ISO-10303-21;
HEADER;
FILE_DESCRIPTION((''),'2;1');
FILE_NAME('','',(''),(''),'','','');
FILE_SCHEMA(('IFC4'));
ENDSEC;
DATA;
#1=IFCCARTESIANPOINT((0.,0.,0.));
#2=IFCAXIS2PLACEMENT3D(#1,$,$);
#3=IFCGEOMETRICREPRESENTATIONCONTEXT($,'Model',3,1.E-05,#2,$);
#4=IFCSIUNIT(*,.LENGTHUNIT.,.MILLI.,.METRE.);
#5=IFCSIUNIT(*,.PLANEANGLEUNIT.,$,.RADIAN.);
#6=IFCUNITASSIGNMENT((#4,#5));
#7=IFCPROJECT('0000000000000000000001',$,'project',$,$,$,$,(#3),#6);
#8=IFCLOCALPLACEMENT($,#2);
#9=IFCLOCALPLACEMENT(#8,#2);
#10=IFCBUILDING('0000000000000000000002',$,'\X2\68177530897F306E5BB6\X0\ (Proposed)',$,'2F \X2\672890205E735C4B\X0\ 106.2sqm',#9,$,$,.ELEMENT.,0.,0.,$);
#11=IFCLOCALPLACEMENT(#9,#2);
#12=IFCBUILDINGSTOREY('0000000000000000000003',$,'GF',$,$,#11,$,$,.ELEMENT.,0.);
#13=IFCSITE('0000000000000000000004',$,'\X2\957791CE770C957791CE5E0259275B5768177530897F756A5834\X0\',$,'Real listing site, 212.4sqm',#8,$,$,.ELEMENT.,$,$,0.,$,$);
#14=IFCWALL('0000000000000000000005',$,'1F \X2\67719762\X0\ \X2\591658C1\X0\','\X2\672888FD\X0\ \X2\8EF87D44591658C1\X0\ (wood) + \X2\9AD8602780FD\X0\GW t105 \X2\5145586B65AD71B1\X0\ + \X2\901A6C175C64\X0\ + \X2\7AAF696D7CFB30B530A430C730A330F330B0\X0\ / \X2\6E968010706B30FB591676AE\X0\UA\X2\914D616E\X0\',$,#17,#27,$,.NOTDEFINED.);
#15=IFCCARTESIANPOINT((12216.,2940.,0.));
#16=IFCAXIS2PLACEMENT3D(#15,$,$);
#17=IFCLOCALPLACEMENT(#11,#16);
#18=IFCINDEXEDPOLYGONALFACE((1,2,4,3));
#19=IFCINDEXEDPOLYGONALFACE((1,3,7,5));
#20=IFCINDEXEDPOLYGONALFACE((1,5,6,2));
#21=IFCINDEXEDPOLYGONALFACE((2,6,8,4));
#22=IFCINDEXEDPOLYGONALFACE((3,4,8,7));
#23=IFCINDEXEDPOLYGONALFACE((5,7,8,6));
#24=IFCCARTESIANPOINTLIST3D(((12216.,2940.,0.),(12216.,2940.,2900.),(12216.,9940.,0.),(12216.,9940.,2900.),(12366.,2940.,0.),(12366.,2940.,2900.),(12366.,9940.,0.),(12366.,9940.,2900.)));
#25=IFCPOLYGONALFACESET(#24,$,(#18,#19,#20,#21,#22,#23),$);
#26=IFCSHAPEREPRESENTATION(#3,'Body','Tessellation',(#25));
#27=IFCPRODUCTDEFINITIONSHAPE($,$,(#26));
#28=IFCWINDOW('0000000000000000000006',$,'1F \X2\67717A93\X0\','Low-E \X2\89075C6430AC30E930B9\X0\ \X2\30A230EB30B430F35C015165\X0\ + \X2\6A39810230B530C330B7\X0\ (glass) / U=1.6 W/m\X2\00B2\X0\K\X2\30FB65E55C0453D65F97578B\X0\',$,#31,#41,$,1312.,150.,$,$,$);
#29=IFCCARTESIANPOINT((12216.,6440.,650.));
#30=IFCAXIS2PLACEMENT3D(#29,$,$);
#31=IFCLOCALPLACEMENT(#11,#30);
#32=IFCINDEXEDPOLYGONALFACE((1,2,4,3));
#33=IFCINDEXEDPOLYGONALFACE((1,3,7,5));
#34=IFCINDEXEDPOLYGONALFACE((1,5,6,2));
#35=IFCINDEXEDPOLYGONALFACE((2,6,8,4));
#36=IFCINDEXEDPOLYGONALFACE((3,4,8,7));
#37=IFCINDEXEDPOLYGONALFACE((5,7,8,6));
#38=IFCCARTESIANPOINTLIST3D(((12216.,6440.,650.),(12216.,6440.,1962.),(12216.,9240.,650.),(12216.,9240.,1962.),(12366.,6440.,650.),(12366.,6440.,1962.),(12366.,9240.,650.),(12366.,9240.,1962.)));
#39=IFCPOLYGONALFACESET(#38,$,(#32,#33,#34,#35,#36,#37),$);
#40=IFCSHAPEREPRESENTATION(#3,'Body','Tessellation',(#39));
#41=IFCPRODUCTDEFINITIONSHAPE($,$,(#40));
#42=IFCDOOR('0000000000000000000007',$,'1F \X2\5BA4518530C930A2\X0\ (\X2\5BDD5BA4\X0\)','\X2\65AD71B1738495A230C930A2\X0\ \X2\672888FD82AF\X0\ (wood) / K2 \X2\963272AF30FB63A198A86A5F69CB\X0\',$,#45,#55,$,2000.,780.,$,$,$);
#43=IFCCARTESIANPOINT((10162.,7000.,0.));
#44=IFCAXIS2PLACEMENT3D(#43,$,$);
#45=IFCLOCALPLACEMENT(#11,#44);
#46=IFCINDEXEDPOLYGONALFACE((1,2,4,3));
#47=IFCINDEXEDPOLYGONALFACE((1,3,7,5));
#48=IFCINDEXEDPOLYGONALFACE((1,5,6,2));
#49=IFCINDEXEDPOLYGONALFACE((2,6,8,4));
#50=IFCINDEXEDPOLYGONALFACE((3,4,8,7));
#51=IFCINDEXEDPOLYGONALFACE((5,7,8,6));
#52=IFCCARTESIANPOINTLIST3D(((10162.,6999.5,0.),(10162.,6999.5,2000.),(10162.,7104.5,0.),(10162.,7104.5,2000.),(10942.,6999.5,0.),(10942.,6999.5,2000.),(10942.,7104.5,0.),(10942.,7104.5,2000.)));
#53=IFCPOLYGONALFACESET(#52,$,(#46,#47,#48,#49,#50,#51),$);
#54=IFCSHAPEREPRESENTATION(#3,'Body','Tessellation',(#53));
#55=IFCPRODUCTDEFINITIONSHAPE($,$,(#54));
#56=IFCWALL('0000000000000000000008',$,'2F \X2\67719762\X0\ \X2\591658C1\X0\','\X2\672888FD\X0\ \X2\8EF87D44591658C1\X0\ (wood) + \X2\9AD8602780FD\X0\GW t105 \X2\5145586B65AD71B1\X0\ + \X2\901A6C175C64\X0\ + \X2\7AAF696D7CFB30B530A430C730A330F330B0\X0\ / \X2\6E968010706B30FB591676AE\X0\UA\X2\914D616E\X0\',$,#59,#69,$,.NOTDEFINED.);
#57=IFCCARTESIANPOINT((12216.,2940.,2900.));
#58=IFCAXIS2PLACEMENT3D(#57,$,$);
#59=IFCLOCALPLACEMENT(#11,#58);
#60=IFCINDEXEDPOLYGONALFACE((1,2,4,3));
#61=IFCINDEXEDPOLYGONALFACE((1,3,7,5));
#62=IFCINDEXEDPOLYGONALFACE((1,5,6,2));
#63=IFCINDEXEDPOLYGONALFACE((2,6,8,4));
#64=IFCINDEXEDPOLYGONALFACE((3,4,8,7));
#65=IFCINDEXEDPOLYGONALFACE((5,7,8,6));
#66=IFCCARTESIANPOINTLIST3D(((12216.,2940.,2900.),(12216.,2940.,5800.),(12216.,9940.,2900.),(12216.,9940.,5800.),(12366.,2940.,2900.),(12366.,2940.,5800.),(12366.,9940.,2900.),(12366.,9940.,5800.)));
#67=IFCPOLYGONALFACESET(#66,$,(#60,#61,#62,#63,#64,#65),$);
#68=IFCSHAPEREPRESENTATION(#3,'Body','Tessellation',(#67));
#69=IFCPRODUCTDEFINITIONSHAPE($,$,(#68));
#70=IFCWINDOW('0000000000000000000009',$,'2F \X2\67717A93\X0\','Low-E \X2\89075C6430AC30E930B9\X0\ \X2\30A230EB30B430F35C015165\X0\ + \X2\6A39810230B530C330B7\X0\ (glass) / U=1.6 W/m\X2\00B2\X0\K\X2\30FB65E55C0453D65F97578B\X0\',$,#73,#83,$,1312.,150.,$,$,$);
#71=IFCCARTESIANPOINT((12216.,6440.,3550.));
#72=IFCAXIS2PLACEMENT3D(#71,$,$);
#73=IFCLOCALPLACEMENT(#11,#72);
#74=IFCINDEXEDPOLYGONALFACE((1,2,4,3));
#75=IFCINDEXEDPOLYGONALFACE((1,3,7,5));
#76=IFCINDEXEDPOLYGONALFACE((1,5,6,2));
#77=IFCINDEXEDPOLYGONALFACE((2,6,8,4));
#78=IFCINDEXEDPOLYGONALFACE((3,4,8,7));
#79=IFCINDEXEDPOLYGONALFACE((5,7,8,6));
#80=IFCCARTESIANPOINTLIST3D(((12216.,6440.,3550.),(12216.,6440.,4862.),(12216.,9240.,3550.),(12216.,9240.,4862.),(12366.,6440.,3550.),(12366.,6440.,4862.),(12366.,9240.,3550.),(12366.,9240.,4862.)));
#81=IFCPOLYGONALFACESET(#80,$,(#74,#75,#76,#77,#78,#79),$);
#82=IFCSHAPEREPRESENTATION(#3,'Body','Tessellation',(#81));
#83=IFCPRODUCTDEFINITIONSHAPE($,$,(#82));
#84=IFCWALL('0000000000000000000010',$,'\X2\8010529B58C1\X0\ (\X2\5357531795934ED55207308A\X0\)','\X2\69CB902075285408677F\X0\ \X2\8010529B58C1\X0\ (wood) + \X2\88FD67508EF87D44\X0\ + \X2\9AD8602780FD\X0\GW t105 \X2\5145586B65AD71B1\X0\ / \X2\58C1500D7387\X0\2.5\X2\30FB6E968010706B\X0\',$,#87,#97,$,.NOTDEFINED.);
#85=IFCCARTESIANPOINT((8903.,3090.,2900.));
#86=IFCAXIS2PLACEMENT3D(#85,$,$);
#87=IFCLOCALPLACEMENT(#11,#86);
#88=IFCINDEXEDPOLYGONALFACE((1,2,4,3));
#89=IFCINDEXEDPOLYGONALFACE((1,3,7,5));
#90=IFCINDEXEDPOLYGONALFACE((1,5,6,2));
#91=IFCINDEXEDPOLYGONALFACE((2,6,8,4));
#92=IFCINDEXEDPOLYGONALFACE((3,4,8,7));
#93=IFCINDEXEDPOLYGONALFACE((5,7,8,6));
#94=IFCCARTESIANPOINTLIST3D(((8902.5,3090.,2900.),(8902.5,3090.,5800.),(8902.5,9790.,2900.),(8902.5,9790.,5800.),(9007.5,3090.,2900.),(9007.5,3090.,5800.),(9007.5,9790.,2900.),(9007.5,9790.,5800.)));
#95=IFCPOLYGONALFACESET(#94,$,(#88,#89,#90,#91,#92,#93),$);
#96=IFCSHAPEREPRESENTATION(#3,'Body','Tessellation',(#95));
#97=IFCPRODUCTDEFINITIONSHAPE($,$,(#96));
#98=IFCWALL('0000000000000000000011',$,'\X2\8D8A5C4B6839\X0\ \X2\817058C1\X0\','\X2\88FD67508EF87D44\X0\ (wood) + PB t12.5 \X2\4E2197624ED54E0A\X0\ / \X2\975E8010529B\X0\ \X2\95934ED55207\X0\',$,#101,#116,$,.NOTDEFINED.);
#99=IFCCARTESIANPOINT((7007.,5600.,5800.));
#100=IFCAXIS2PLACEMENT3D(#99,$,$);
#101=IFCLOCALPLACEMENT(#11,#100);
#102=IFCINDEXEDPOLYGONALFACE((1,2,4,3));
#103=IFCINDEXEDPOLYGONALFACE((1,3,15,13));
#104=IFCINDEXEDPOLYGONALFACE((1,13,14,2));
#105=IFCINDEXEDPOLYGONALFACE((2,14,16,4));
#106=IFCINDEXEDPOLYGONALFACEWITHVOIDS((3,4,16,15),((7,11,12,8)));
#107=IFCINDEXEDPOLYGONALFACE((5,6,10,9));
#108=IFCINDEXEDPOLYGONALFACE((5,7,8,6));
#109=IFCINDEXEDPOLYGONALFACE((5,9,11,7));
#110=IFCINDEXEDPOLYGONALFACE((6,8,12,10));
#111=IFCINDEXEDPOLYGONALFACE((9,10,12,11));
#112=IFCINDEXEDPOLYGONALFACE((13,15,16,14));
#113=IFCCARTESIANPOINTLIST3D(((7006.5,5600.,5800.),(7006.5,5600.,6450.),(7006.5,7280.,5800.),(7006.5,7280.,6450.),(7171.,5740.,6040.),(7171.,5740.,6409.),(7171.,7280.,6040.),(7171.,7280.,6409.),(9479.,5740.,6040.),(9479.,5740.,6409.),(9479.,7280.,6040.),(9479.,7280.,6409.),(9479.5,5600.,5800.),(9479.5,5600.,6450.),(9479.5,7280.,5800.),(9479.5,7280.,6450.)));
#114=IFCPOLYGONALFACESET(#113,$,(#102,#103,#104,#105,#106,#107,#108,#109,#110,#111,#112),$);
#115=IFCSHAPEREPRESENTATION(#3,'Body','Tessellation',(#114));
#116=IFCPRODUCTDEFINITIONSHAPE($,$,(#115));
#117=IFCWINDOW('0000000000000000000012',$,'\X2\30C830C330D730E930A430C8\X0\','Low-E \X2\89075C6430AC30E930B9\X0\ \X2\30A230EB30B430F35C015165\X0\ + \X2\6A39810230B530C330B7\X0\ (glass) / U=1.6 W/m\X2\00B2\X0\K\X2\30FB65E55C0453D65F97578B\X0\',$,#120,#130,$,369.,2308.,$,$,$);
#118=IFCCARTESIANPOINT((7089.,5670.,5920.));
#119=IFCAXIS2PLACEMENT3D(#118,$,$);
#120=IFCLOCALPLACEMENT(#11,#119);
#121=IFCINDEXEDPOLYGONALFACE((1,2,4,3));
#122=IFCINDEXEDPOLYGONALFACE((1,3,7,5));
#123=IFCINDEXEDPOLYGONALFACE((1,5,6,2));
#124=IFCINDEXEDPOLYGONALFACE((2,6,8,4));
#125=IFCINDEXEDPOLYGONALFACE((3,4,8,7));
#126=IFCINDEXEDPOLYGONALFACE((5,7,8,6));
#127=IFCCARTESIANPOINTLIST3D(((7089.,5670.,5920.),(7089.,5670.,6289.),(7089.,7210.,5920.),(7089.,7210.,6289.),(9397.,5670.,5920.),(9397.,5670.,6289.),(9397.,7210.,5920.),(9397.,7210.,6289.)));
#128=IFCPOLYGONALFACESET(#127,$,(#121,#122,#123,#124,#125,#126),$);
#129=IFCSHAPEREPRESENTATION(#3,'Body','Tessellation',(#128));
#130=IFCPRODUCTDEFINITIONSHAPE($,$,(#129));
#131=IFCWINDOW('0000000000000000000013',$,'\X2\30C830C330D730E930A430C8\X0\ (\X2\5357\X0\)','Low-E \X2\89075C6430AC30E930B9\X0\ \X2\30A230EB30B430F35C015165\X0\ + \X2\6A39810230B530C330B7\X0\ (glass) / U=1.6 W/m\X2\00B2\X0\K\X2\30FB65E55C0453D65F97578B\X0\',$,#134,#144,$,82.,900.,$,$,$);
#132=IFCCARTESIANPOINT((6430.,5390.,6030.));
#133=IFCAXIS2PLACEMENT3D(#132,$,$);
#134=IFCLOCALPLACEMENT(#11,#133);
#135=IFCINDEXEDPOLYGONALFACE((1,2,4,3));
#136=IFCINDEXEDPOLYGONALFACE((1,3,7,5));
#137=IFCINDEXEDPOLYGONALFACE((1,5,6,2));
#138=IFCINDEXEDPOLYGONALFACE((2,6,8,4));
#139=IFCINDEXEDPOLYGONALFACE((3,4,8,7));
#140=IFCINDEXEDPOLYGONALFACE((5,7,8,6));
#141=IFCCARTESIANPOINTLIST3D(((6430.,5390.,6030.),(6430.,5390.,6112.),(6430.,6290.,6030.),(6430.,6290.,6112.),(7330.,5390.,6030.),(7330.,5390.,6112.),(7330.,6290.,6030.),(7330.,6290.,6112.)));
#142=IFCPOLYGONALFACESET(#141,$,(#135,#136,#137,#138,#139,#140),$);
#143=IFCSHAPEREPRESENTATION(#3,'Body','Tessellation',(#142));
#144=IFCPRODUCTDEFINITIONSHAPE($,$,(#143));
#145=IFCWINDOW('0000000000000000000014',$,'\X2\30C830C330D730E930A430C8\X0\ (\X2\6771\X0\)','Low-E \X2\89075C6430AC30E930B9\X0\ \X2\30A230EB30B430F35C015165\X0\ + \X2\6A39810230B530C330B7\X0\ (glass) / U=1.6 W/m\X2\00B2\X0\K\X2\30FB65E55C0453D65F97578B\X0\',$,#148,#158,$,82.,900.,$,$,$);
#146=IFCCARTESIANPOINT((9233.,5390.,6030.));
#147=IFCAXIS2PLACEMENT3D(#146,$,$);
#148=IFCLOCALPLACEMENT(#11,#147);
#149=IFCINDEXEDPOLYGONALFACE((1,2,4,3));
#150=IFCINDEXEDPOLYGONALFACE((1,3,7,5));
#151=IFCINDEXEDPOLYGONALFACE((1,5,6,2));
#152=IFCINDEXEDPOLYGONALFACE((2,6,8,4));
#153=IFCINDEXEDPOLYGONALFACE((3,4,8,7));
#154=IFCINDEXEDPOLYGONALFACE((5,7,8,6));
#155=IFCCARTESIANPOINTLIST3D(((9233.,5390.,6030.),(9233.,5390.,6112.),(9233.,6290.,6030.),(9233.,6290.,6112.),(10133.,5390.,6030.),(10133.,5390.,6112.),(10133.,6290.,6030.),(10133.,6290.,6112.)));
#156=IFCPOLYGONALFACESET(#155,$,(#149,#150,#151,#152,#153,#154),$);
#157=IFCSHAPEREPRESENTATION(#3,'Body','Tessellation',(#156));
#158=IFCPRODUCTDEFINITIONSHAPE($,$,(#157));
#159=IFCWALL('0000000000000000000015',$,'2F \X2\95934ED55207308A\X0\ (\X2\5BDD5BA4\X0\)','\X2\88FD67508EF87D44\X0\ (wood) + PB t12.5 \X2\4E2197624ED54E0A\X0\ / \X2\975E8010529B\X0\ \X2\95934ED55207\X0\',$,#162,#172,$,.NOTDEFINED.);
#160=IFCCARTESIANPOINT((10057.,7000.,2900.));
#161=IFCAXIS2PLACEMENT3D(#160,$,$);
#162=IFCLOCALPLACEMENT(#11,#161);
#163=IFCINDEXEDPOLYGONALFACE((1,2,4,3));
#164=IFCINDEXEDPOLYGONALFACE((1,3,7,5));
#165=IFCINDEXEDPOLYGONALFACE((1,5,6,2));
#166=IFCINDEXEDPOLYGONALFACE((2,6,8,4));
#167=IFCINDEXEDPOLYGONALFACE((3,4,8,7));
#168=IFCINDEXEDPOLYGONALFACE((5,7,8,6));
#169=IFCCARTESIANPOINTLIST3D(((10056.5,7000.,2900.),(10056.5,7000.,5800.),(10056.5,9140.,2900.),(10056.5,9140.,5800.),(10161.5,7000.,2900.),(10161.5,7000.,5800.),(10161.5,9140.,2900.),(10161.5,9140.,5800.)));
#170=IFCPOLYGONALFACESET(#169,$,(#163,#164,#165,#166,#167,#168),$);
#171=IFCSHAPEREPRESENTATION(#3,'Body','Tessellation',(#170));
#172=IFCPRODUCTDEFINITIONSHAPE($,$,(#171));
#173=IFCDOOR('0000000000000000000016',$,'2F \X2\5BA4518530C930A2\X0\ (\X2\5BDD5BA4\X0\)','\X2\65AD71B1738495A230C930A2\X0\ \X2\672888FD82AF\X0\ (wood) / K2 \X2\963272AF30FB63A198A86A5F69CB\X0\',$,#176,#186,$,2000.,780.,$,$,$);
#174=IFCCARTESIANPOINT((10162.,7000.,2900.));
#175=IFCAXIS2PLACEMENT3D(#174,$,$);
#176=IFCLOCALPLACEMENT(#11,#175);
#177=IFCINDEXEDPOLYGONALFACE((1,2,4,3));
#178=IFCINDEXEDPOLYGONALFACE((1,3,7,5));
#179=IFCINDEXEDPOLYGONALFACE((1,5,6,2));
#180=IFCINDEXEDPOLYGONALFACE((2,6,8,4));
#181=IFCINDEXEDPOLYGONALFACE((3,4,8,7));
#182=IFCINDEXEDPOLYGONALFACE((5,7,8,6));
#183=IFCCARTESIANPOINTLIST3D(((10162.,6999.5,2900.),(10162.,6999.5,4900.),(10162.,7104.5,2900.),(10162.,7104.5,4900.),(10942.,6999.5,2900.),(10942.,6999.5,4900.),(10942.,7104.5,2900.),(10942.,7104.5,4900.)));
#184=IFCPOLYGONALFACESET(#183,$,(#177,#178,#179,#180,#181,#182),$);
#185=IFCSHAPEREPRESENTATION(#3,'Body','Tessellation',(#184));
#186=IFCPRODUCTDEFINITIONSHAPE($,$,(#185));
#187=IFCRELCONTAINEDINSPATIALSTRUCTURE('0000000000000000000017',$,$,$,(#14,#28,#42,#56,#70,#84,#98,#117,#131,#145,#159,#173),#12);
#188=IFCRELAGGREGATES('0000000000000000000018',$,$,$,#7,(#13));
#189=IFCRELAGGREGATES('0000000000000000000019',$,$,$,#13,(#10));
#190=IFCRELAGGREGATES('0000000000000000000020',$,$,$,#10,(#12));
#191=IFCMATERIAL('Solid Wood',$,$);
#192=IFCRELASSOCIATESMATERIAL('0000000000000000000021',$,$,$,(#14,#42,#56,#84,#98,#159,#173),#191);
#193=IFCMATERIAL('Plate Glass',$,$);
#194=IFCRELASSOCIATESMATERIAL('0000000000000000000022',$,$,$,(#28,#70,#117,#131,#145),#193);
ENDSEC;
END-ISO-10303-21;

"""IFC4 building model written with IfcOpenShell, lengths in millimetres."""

from ifc_helpers import new_model, si_unit, frame, frame_2d, origin, place, context, project, spatial, rectangle, extrude, material, element, fill, save


model = new_model("IFC4")

# Units and contexts
model_context = context("Model", 3, precision=1e-05, world=origin())
ifc_project = project(units=[si_unit("LENGTHUNIT", "METRE", prefix="MILLI"), si_unit("PLANEANGLEUNIT", "RADIAN")], contexts=[model_context])

# Site, building, storey
site_placement = place(None, origin())
site = spatial("IfcSite", under=ifc_project, at=site_placement, Name="長野県長野市大字栗田西番場", ObjectType="Real listing site, 212.4sqm", CompositionType="ELEMENT", RefElevation=0.0)
building_placement = place(site_placement, origin())
building = spatial("IfcBuilding", under=site, at=building_placement, Name="栗田西の家 (Proposed)", ObjectType="2F 木造平屋 106.2sqm", CompositionType="ELEMENT", ElevationOfRefHeight=0.0, ElevationOfTerrain=0.0)
storey_placement = place(building_placement, origin())
storey = spatial("IfcBuildingStorey", under=building, at=storey_placement, Name="GF", CompositionType="ELEMENT", Elevation=0.0)

# Wall, opening, window
ifc_material_1 = material(Name="Solid Wood")
wall_1_placement = place(storey_placement, frame((12216.0, 2940.0, 0.0)))
wall_1 = element("IfcWall", 1, at=wall_1_placement, inside=storey, material=ifc_material_1, Name="1F 東面 外壁", Description="木製 軸組外壁 (wood) + 高性能GW t105 充填断熱 + 通気層 + 窯業系サイディング / 準耐火・外皮UA配慮", PredefinedType="NOTDEFINED", context=model_context, shape_type="SweptSolid", body=[
    extrude(rectangle(XDim=150.0, YDim=7000.0, at=frame_2d((75.0, 3500.0))), frame((12216.0, 2940.0, 0.0)), (0.0, 0.0, 1.0), 2900.0),
])
opening_1_placement = place(storey_placement, frame((12216.0, 6440.0, 650.0)))
opening_1 = element("IfcOpeningElement", 2, at=opening_1_placement, cuts=wall_1, PredefinedType="NOTDEFINED", context=model_context, shape_type="SweptSolid", body=[
    extrude(rectangle(XDim=150.0, YDim=2800.0, at=frame_2d((75.0, 1400.0))), frame((12216.0, 6440.0, 650.0)), (0.0, 0.0, 1.0), 1312.0),
])
ifc_material_2 = material(Name="Plate Glass")
window_1_placement = place(storey_placement, frame((12216.0, 6440.0, 650.0)))
window_1 = element("IfcWindow", 3, at=window_1_placement, inside=storey, material=ifc_material_2, Name="1F 東窓", Description="Low-E 複層ガラス アルゴン封入 + 樹脂サッシ (glass) / U=1.6 W/m²K・日射取得型", OverallHeight=1312.0, OverallWidth=150.0, context=model_context, shape_type="SweptSolid", body=[
    extrude(rectangle(XDim=150.0, YDim=2800.0, at=frame_2d((75.0, 1400.0))), frame((12216.0, 6440.0, 650.0)), (0.0, 0.0, 1.0), 1312.0),
])
fill(opening_1, window_1)

# Door
door_1_placement = place(storey_placement, frame((10162.0, 7000.0, 0.0)))
element("IfcDoor", 4, at=door_1_placement, inside=storey, material=ifc_material_1, Name="1F 室内ドア (寝室)", Description="断熱玄関ドア 木製芯 (wood) / K2 防犯・採風機構", OverallHeight=2000.0, OverallWidth=780.0, context=model_context, shape_type="SweptSolid", body=[
    extrude(rectangle(XDim=780.0, YDim=105.0, at=frame_2d((390.0, 52.0))), frame((10162.0, 7000.0, 0.0)), (0.0, 0.0, 1.0), 2000.0),
])

# Wall, opening, window
wall_2_placement = place(storey_placement, frame((12216.0, 2940.0, 2900.0)))
wall_2 = element("IfcWall", 5, at=wall_2_placement, inside=storey, material=ifc_material_1, Name="2F 東面 外壁", Description="木製 軸組外壁 (wood) + 高性能GW t105 充填断熱 + 通気層 + 窯業系サイディング / 準耐火・外皮UA配慮", PredefinedType="NOTDEFINED", context=model_context, shape_type="SweptSolid", body=[
    extrude(rectangle(XDim=150.0, YDim=7000.0, at=frame_2d((75.0, 3500.0))), frame((12216.0, 2940.0, 2900.0)), (0.0, 0.0, 1.0), 2900.0),
])
opening_2_placement = place(storey_placement, frame((12216.0, 6440.0, 3550.0)))
opening_2 = element("IfcOpeningElement", 6, at=opening_2_placement, cuts=wall_2, PredefinedType="NOTDEFINED", context=model_context, shape_type="SweptSolid", body=[
    extrude(rectangle(XDim=150.0, YDim=2800.0, at=frame_2d((75.0, 1400.0))), frame((12216.0, 6440.0, 3550.0)), (0.0, 0.0, 1.0), 1312.0),
])
window_2_placement = place(storey_placement, frame((12216.0, 6440.0, 3550.0)))
window_2 = element("IfcWindow", 7, at=window_2_placement, inside=storey, material=ifc_material_2, Name="2F 東窓", Description="Low-E 複層ガラス アルゴン封入 + 樹脂サッシ (glass) / U=1.6 W/m²K・日射取得型", OverallHeight=1312.0, OverallWidth=150.0, context=model_context, shape_type="SweptSolid", body=[
    extrude(rectangle(XDim=150.0, YDim=2800.0, at=frame_2d((75.0, 1400.0))), frame((12216.0, 6440.0, 3550.0)), (0.0, 0.0, 1.0), 1312.0),
])
fill(opening_2, window_2)

# Wall
wall_3_placement = place(storey_placement, frame((8903.0, 3090.0, 2900.0)))
element("IfcWall", 8, at=wall_3_placement, inside=storey, material=ifc_material_1, Name="耐力壁 (南北間仕切り)", Description="構造用合板 耐力壁 (wood) + 製材軸組 + 高性能GW t105 充填断熱 / 壁倍率2.5・準耐火", PredefinedType="NOTDEFINED", context=model_context, shape_type="SweptSolid", body=[
    extrude(rectangle(XDim=105.0, YDim=6700.0, at=frame_2d((52.0, 3350.0))), frame((8903.0, 3090.0, 2900.0)), (0.0, 0.0, 1.0), 2900.0),
])

# Wall, openings, windows
wall_4_placement = place(storey_placement, frame((7007.0, 5600.0, 5800.0)))
wall_4 = element("IfcWall", 9, at=wall_4_placement, inside=storey, material=ifc_material_1, Name="越屋根 腰壁", Description="製材軸組 (wood) + PB t12.5 両面仕上 / 非耐力 間仕切", PredefinedType="NOTDEFINED", context=model_context, shape_type="SweptSolid", body=[
    extrude(rectangle(XDim=2473.0, YDim=1680.0, at=frame_2d((1236.0, 840.0))), frame((7007.0, 5600.0, 5800.0)), (0.0, 0.0, 1.0), 650.0),
])
opening_3_placement = place(storey_placement, frame((7089.0, 5670.0, 5920.0)))
opening_3 = element("IfcOpeningElement", 10, at=opening_3_placement, cuts=wall_4, PredefinedType="NOTDEFINED", context=model_context, shape_type="SweptSolid", body=[
    extrude(rectangle(XDim=2308.0, YDim=1540.0, at=frame_2d((1154.0, 770.0))), frame((7089.0, 5670.0, 5920.0)), (0.0, 0.0, 1.0), 369.0),
])
opening_4_placement = place(storey_placement, frame((6430.0, 5390.0, 6030.0)))
opening_4 = element("IfcOpeningElement", 11, at=opening_4_placement, cuts=wall_4, PredefinedType="NOTDEFINED", context=model_context, shape_type="SweptSolid", body=[
    extrude(rectangle(XDim=900.0, YDim=900.0, at=frame_2d((450.0, 450.0))), frame((6430.0, 5390.0, 6030.0)), (0.0, 0.0, 1.0), 82.0),
])
opening_5_placement = place(storey_placement, frame((9233.0, 5390.0, 6030.0)))
opening_5 = element("IfcOpeningElement", 12, at=opening_5_placement, cuts=wall_4, PredefinedType="NOTDEFINED", context=model_context, shape_type="SweptSolid", body=[
    extrude(rectangle(XDim=900.0, YDim=900.0, at=frame_2d((450.0, 450.0))), frame((9233.0, 5390.0, 6030.0)), (0.0, 0.0, 1.0), 82.0),
])
window_3_placement = place(storey_placement, frame((7089.0, 5670.0, 5920.0)))
window_3 = element("IfcWindow", 13, at=window_3_placement, inside=storey, material=ifc_material_2, Name="トップライト", Description="Low-E 複層ガラス アルゴン封入 + 樹脂サッシ (glass) / U=1.6 W/m²K・日射取得型", OverallHeight=369.0, OverallWidth=2308.0, context=model_context, shape_type="SweptSolid", body=[
    extrude(rectangle(XDim=2308.0, YDim=1540.0, at=frame_2d((1154.0, 770.0))), frame((7089.0, 5670.0, 5920.0)), (0.0, 0.0, 1.0), 369.0),
])
fill(opening_3, window_3)
window_4_placement = place(storey_placement, frame((6430.0, 5390.0, 6030.0)))
window_4 = element("IfcWindow", 14, at=window_4_placement, inside=storey, material=ifc_material_2, Name="トップライト (南)", Description="Low-E 複層ガラス アルゴン封入 + 樹脂サッシ (glass) / U=1.6 W/m²K・日射取得型", OverallHeight=82.0, OverallWidth=900.0, context=model_context, shape_type="SweptSolid", body=[
    extrude(rectangle(XDim=900.0, YDim=900.0, at=frame_2d((450.0, 450.0))), frame((6430.0, 5390.0, 6030.0)), (0.0, 0.0, 1.0), 82.0),
])
fill(opening_4, window_4)
window_5_placement = place(storey_placement, frame((9233.0, 5390.0, 6030.0)))
window_5 = element("IfcWindow", 15, at=window_5_placement, inside=storey, material=ifc_material_2, Name="トップライト (東)", Description="Low-E 複層ガラス アルゴン封入 + 樹脂サッシ (glass) / U=1.6 W/m²K・日射取得型", OverallHeight=82.0, OverallWidth=900.0, context=model_context, shape_type="SweptSolid", body=[
    extrude(rectangle(XDim=900.0, YDim=900.0, at=frame_2d((450.0, 450.0))), frame((9233.0, 5390.0, 6030.0)), (0.0, 0.0, 1.0), 82.0),
])
fill(opening_5, window_5)

# Wall
wall_5_placement = place(storey_placement, frame((10057.0, 7000.0, 2900.0)))
element("IfcWall", 16, at=wall_5_placement, inside=storey, material=ifc_material_1, Name="2F 間仕切り (寝室)", Description="製材軸組 (wood) + PB t12.5 両面仕上 / 非耐力 間仕切", PredefinedType="NOTDEFINED", context=model_context, shape_type="SweptSolid", body=[
    extrude(rectangle(XDim=105.0, YDim=2140.0, at=frame_2d((52.0, 1070.0))), frame((10057.0, 7000.0, 2900.0)), (0.0, 0.0, 1.0), 2900.0),
])

# Door
door_2_placement = place(storey_placement, frame((10162.0, 7000.0, 2900.0)))
element("IfcDoor", 17, at=door_2_placement, inside=storey, material=ifc_material_1, Name="2F 室内ドア (寝室)", Description="断熱玄関ドア 木製芯 (wood) / K2 防犯・採風機構", OverallHeight=2000.0, OverallWidth=780.0, context=model_context, shape_type="SweptSolid", body=[
    extrude(rectangle(XDim=780.0, YDim=105.0, at=frame_2d((390.0, 52.0))), frame((10162.0, 7000.0, 2900.0)), (0.0, 0.0, 1.0), 2000.0),
])

save(model, "model.ifc")
